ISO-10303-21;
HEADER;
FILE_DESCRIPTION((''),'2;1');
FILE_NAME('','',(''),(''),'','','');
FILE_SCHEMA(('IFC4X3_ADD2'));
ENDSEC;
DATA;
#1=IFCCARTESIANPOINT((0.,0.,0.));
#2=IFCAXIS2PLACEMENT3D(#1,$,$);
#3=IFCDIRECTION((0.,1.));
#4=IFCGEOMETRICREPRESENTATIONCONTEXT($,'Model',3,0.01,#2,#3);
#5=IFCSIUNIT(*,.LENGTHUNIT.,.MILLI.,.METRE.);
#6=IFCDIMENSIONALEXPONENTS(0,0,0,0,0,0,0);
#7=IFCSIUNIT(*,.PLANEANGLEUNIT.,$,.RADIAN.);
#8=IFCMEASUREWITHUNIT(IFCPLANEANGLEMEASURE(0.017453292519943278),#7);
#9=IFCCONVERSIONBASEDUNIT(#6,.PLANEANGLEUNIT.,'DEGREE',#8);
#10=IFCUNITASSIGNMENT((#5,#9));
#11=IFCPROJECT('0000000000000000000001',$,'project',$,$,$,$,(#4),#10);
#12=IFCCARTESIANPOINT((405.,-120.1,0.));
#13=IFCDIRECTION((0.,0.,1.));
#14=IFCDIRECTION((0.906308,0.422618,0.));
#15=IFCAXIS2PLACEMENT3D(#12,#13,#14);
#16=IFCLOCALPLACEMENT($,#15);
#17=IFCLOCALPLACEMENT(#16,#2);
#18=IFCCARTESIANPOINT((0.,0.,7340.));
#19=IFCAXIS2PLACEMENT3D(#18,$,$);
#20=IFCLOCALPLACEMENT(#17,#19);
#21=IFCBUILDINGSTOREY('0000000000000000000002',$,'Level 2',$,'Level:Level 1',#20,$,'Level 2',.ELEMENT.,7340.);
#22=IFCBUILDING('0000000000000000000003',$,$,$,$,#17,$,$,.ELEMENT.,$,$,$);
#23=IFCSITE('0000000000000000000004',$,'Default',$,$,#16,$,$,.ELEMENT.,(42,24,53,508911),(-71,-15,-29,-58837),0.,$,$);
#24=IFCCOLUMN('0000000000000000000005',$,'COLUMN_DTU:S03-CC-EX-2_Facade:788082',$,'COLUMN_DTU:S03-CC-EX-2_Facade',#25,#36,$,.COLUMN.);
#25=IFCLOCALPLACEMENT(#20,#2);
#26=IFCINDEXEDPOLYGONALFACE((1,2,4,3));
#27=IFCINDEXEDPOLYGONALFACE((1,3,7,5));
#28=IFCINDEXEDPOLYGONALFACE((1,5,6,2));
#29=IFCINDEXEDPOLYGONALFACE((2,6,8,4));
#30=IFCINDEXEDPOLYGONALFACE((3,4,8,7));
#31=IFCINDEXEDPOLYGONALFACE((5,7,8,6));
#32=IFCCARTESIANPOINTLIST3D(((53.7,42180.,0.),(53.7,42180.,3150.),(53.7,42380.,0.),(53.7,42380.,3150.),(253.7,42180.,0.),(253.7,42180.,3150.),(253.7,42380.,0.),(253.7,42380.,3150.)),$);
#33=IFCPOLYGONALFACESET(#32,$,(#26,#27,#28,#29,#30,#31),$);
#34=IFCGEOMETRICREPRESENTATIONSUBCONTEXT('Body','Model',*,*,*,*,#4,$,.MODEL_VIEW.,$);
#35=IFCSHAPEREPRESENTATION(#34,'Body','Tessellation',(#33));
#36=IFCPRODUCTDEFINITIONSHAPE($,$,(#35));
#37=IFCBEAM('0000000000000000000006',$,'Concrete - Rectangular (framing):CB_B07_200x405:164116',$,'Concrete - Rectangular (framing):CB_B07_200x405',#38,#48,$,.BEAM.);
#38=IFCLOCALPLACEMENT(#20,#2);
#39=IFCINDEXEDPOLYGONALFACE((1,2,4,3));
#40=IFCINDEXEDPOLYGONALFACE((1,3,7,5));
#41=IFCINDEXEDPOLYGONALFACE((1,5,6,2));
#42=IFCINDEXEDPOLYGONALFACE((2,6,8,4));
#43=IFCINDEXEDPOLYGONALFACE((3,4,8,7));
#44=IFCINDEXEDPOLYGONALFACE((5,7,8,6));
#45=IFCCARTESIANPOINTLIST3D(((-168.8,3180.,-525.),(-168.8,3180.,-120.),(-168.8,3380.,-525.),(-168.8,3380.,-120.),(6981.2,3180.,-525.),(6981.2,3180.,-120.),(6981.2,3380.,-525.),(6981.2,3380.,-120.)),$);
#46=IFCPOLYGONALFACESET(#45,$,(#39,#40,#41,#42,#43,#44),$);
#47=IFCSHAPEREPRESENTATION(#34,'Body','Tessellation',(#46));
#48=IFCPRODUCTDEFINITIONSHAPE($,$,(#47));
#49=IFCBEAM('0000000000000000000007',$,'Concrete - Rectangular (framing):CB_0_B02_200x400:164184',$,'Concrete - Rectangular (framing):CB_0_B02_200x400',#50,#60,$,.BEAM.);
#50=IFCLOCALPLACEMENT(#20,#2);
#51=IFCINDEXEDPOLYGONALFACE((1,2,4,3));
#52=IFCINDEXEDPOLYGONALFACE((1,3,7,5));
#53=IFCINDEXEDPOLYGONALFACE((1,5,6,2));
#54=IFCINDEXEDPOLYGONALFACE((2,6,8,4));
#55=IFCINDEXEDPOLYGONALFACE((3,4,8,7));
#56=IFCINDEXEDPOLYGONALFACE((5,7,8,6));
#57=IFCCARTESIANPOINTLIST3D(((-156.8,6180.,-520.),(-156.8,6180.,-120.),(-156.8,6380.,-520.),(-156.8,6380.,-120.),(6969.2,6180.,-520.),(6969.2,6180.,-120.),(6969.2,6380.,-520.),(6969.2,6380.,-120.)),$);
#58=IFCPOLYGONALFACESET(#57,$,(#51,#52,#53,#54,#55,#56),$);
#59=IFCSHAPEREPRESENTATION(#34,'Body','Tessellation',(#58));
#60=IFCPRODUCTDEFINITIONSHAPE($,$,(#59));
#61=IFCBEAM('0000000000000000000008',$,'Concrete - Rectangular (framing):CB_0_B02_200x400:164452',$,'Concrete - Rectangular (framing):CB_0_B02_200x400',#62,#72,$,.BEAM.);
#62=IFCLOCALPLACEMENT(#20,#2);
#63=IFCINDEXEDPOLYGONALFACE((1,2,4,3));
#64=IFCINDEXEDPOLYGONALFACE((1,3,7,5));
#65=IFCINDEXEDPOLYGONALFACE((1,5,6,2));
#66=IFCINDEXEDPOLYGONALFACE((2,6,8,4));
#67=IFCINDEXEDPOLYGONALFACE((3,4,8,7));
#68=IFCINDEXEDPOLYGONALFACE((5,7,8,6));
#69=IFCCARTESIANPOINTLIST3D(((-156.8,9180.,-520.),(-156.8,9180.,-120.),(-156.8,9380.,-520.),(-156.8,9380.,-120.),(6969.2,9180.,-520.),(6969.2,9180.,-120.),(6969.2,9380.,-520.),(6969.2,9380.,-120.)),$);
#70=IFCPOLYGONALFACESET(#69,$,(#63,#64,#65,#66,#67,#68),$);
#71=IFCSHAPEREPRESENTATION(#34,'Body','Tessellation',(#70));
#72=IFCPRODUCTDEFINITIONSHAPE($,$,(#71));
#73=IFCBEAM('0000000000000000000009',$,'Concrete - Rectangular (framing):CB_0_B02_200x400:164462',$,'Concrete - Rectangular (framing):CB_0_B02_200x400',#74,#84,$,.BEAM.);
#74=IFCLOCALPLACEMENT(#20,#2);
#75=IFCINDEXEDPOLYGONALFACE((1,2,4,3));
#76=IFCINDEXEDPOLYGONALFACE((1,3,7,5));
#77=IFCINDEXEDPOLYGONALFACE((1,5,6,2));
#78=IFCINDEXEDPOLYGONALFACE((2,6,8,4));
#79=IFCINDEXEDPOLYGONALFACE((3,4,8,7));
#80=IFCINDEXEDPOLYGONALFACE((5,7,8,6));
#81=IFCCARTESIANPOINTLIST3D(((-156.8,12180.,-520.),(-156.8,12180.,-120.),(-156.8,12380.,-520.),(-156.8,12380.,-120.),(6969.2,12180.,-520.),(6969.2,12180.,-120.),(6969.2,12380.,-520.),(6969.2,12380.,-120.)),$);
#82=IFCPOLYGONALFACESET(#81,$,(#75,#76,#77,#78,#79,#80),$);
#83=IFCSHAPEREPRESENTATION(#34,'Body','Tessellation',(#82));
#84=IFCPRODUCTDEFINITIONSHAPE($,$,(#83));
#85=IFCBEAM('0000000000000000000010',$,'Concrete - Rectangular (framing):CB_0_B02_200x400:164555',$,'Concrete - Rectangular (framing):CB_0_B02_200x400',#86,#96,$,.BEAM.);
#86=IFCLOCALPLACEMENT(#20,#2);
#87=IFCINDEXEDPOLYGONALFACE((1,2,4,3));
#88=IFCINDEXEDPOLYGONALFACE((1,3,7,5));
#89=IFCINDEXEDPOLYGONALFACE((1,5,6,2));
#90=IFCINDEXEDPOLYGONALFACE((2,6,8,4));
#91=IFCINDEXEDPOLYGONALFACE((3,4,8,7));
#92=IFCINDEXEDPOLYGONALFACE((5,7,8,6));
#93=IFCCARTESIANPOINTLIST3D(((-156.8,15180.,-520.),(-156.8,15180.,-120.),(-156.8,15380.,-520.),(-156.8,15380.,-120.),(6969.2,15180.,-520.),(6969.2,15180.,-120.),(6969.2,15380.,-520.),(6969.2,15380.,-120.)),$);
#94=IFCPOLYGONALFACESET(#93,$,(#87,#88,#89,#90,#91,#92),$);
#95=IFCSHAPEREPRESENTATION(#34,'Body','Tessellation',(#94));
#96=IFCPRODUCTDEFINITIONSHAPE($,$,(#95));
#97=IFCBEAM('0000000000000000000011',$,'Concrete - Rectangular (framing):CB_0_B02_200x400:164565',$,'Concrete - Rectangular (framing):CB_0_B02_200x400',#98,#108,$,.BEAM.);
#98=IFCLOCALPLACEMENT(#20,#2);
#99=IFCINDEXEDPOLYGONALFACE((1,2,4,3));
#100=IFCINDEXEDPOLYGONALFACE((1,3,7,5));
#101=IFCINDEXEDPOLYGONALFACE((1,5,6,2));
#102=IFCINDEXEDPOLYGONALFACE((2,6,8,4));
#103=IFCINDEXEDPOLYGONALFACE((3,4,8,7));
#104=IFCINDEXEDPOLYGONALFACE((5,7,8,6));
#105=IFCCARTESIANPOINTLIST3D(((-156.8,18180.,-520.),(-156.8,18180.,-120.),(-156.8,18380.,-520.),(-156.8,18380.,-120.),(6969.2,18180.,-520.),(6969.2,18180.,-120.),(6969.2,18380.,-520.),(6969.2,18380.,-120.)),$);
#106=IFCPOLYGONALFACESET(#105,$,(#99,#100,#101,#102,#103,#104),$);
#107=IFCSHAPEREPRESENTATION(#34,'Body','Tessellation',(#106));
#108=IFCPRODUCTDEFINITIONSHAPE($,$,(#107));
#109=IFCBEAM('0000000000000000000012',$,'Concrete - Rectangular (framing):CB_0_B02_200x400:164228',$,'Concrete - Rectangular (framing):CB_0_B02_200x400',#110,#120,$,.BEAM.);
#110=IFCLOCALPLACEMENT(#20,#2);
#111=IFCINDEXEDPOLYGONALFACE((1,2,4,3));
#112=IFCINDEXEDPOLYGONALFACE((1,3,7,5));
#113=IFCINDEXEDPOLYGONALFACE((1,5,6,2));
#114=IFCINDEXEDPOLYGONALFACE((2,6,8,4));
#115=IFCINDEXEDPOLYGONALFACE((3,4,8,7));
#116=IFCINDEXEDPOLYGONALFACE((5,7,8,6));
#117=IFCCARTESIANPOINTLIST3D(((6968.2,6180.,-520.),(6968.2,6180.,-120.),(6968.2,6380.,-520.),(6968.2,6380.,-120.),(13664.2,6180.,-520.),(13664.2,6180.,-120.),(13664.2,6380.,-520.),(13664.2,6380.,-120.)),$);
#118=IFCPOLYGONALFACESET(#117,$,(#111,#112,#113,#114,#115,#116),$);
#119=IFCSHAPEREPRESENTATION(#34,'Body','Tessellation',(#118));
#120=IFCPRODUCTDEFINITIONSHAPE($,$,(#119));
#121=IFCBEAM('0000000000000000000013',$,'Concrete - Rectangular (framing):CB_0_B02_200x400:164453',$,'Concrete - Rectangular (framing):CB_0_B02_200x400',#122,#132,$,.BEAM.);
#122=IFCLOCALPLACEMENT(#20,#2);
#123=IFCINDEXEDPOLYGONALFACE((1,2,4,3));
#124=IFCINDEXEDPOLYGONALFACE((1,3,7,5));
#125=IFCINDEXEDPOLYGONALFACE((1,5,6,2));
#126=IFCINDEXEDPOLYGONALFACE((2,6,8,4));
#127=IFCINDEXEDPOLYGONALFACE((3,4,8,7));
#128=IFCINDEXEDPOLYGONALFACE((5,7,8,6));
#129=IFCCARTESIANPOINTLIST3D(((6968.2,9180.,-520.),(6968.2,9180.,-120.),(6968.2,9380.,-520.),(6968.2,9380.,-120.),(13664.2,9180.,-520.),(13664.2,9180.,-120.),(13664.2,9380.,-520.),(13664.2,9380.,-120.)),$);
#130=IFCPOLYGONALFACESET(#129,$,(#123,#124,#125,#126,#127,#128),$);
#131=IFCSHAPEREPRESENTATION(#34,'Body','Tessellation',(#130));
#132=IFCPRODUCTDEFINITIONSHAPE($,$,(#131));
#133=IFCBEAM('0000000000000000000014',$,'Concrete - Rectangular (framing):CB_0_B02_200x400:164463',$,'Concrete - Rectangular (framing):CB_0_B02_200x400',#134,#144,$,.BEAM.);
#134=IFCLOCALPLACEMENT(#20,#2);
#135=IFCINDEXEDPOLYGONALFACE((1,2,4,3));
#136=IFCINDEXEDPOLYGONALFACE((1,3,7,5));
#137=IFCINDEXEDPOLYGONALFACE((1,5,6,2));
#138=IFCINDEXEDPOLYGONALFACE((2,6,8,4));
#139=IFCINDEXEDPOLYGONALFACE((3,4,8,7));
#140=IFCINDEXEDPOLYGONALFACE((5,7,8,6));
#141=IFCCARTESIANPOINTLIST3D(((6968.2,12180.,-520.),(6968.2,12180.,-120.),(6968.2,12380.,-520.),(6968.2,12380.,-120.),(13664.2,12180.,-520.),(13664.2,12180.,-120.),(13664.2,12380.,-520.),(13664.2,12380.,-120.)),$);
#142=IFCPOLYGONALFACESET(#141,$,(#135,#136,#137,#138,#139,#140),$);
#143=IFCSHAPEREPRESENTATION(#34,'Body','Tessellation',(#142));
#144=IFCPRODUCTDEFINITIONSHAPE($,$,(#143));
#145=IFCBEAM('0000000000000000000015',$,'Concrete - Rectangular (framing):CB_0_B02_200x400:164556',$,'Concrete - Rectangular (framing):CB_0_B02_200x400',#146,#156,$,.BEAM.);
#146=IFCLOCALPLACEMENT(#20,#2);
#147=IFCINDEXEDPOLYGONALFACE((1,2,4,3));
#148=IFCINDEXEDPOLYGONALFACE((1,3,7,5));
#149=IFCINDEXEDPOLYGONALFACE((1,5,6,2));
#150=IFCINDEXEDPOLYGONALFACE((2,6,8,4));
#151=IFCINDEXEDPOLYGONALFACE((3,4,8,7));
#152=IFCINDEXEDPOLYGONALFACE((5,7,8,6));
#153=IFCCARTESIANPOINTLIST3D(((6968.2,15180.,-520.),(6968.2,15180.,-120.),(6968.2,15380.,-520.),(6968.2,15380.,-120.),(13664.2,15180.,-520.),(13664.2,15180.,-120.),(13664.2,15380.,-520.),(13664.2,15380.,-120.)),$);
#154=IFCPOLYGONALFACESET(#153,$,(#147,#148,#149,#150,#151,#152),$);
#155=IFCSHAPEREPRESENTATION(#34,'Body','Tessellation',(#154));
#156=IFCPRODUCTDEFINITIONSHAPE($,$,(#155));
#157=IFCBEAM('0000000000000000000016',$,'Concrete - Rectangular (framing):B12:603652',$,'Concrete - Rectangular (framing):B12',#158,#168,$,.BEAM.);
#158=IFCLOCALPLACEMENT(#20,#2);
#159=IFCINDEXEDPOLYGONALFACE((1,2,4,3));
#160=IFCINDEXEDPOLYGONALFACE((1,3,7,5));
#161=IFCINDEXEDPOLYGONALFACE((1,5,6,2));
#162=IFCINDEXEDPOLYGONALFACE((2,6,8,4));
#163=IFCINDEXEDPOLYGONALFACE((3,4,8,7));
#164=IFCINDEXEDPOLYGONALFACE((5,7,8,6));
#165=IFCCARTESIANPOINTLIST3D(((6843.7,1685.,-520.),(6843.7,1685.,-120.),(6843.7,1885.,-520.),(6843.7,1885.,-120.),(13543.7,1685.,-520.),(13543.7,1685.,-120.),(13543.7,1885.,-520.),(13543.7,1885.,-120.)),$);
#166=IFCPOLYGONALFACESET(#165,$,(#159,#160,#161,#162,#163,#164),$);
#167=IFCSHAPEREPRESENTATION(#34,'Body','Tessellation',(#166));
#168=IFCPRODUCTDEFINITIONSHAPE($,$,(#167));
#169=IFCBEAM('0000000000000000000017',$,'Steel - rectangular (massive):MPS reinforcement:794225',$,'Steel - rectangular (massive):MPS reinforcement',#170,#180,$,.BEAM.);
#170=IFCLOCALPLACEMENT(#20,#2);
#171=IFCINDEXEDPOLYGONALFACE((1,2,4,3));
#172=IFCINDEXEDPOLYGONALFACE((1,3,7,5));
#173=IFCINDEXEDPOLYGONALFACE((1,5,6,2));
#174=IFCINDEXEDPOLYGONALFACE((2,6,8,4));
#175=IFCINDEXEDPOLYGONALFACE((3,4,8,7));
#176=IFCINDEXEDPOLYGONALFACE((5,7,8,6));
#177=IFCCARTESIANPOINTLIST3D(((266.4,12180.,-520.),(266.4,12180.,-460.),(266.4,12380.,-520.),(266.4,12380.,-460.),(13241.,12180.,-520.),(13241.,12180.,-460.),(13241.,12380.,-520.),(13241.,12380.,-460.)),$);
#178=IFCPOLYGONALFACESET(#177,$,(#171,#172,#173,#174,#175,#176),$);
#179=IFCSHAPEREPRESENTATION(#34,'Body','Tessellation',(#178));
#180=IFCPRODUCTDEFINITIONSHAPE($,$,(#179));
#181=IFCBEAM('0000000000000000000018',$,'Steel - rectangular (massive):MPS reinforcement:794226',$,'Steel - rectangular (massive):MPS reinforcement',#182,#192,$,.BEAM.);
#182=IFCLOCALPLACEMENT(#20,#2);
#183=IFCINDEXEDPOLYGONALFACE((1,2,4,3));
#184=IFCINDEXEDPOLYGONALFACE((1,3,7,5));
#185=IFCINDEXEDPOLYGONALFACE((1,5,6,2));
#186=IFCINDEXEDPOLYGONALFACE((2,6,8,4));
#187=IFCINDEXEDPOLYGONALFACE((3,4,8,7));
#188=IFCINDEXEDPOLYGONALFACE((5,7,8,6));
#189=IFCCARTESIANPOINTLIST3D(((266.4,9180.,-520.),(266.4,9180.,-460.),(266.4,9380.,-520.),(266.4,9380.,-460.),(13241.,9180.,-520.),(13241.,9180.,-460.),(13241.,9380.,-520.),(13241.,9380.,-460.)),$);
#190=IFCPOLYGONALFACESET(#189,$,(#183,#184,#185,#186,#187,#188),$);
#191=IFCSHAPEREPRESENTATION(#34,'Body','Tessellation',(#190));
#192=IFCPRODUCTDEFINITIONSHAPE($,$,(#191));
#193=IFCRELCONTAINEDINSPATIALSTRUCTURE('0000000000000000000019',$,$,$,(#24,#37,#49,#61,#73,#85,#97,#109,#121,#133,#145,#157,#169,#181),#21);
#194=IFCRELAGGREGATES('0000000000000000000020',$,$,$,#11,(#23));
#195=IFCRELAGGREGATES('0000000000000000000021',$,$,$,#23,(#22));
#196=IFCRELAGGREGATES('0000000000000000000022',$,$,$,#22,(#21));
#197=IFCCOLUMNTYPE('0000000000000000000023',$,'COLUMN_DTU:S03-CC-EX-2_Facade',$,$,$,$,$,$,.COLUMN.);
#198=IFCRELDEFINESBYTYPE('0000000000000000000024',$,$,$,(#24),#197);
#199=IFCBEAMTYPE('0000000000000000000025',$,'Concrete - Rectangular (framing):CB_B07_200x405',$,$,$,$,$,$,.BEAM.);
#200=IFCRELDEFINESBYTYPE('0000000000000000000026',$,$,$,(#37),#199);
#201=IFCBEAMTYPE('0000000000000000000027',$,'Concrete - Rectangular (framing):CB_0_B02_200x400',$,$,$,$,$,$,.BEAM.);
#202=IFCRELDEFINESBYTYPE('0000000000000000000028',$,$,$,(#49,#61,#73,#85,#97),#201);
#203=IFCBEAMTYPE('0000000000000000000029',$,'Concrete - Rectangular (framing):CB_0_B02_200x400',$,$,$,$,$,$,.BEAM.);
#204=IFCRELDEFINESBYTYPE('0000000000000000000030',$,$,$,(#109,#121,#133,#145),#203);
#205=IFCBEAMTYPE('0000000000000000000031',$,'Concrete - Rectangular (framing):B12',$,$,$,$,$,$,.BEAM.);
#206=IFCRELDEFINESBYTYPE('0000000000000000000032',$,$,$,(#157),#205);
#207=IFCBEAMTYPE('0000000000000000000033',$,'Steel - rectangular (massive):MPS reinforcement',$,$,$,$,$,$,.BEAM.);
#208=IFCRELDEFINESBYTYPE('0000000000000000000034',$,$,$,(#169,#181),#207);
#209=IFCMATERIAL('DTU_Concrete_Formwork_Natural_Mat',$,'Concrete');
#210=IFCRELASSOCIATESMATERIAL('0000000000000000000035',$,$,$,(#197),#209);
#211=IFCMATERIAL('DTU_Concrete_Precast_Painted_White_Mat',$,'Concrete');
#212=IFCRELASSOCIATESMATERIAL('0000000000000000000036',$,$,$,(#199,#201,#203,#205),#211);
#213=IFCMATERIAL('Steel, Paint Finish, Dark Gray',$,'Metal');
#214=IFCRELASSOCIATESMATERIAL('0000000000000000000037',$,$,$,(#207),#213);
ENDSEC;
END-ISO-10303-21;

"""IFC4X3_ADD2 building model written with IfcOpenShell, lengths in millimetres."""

from ifc_helpers import new_model, entity, si_unit, converted_unit, direction, frame, frame_2d, origin, origin_2d_with_axis, place, context, subcontext, project, spatial, rectangle, extrude, source, transform, mapped, material, material_profile, profile_set, type_object, type_shapes, element, save


model = new_model("IFC4X3_ADD2")

# Units and contexts
model_context = context("Model", 3, precision=0.01, world=origin(), true_north=direction((0.0, 1.0)))
body_context = subcontext(model_context, "Body", "Model", "MODEL_VIEW")
ifc_project = project(units=[si_unit("LENGTHUNIT", "METRE", prefix="MILLI"), converted_unit("PLANEANGLEUNIT", "DEGREE", entity("IfcPlaneAngleMeasure", 0.017453292519943278), si_unit("PLANEANGLEUNIT", "RADIAN"), dimensions=[0, 0, 0, 0, 0, 0, 0])], contexts=[model_context])

# Site, building, storey
site_placement = place(None, frame((405.0, -120.1, 0.0), z_axis=(0.0, 0.0, 1.0), x_axis=(0.906308, 0.422618, 0.0)))
site = spatial("IfcSite", under=ifc_project, at=site_placement, Name="Default", CompositionType="ELEMENT", RefLatitude=(42, 24, 53, 508911), RefLongitude=(-71, -15, -29, -58837), RefElevation=0.0)
building_placement = place(site_placement, origin())
building = spatial("IfcBuilding", under=site, at=building_placement, CompositionType="ELEMENT")
storey_placement = place(building_placement, frame((0.0, 0.0, 7340.0)))
storey = spatial("IfcBuildingStorey", under=building, at=storey_placement, Name="Level 2", ObjectType="Level:Level 1", LongName="Level 2", CompositionType="ELEMENT", Elevation=7340.0)

# Column
ifc_material_1 = material(Name="DTU_Concrete_Formwork_Natural_Mat", Category="Concrete")
ifc_material_profile_1 = material_profile(ifc_material_1, rectangle(XDim=200.0, YDim=200.0, at=frame_2d((0.0, 0.0), x_axis=(1.0, 0.0))), Name="S03-CC-EX-2_Facade")
ifc_profile_set_1 = profile_set([ifc_material_profile_1], Name="S03-CC-EX-2_Facade")
column_type = type_object("IfcColumnType", Name="COLUMN_DTU:S03-CC-EX-2_Facade", PredefinedType="COLUMN", material=ifc_profile_set_1)
shared_shape_1 = source(origin(), body_context, "Body", "SweptSolid", [
    extrude(rectangle(XDim=200.0, YDim=200.0, at=frame_2d((0.0, 0.0), x_axis=(1.0, 0.0))), frame((153.7, 42280.0, 7340.0), z_axis=(0.0, 0.0, 1.0), x_axis=(0.0, -1.0, 0.0)), (0.0, 0.0, 1.0), 3150.0),
])
type_shapes(column_type, [shared_shape_1])
column_placement = place(storey_placement, frame((0.0, 0.0, -7340.0)))
element("IfcColumn", 1, at=column_placement, inside=storey, type_object=column_type, Name="COLUMN_DTU:S03-CC-EX-2_Facade:788082", ObjectType="COLUMN_DTU:S03-CC-EX-2_Facade", PredefinedType="COLUMN", context=body_context, shape_type="MappedRepresentation", body=[
    mapped(shared_shape_1, transform((0.0, 0.0, 0.0), scale=1.0)),
])

# Beams
ifc_material_2 = material(Name="DTU_Concrete_Precast_Painted_White_Mat", Category="Concrete")
ifc_material_profile_2 = material_profile(ifc_material_2, rectangle(XDim=6850.0, YDim=200.0, at=origin_2d_with_axis()), Name="CB_B07_200x405")
ifc_profile_set_2 = profile_set([ifc_material_profile_2], Name="CB_B07_200x405")
beam_type_1 = type_object("IfcBeamType", Name="Concrete - Rectangular (framing):CB_B07_200x405", PredefinedType="BEAM", material=ifc_profile_set_2)
shared_shape_2 = source(origin(), body_context, "Body", "SweptSolid", [
    extrude(rectangle(XDim=7150.0, YDim=200.0, at=frame_2d((0.0, 0.0), x_axis=(1.0, 0.0))), frame((0.0, 0.0, -202.5), z_axis=(0.0, 0.0, 1.0), x_axis=(-1.0, 0.0, 0.0)), (0.0, 0.0, 1.0), 405.0),
])
type_shapes(beam_type_1, [shared_shape_2])
beam_1_placement = place(storey_placement, frame((3406.2, 3280.0, -322.5), z_axis=(0.0, 0.0, 1.0), x_axis=(-1.0, 0.0, 0.0)))
element("IfcBeam", 2, at=beam_1_placement, inside=storey, type_object=beam_type_1, Name="Concrete - Rectangular (framing):CB_B07_200x405:164116", ObjectType="Concrete - Rectangular (framing):CB_B07_200x405", PredefinedType="BEAM", context=body_context, shape_type="MappedRepresentation", body=[
    mapped(shared_shape_2, transform((0.0, 0.0, 0.0), scale=1.0)),
])
ifc_material_profile_3 = material_profile(ifc_material_2, rectangle(XDim=7035.5, YDim=200.0, at=frame_2d((0.0, 0.0), x_axis=(1.0, 0.0))), Name="CB_0_B02_200x400")
ifc_profile_set_3 = profile_set([ifc_material_profile_3], Name="CB_0_B02_200x400")
beam_type_2 = type_object("IfcBeamType", Name="Concrete - Rectangular (framing):CB_0_B02_200x400", PredefinedType="BEAM", material=ifc_profile_set_3)
shared_shape_3 = source(origin(), body_context, "Body", "SweptSolid", [
    extrude(rectangle(XDim=7126.0, YDim=200.0, at=origin_2d_with_axis()), frame((0.0, 0.0, -200.0), z_axis=(0.0, 0.0, 1.0), x_axis=(-1.0, 0.0, 0.0)), (0.0, 0.0, 1.0), 400.0),
])
type_shapes(beam_type_2, [shared_shape_3])
for number, where, z_axis, x_axis, name in (
    (3, (3406.2, 6280.0, -320.0), (0.0, 0.0, 1.0), (-1.0, 0.0, 0.0), "Concrete - Rectangular (framing):CB_0_B02_200x400:164184"),
    (4, (3406.2, 9280.0, -320.0), (0.0, 0.0, 1.0), (-1.0, 0.0, 0.0), "Concrete - Rectangular (framing):CB_0_B02_200x400:164452"),
    (5, (3406.2, 12280.0, -320.0), (0.0, 0.0, 1.0), (-1.0, 0.0, 0.0), "Concrete - Rectangular (framing):CB_0_B02_200x400:164462"),
    (6, (3406.2, 15280.0, -320.0), (0.0, 0.0, 1.0), (-1.0, 0.0, 0.0), "Concrete - Rectangular (framing):CB_0_B02_200x400:164555"),
    (7, (3406.2, 18280.0, -320.0), (0.0, 0.0, 1.0), (-1.0, 0.0, 0.0), "Concrete - Rectangular (framing):CB_0_B02_200x400:164565"),
):
    element("IfcBeam", number, at=place(storey_placement, frame(where, z_axis=z_axis, x_axis=x_axis)), inside=storey, type_object=beam_type_2, Name=name, ObjectType="Concrete - Rectangular (framing):CB_0_B02_200x400", PredefinedType="BEAM", context=body_context, shape_type="MappedRepresentation", body=[
        mapped(shared_shape_3, transform((0.0, 0.0, 0.0), scale=1.0)),
    ])
beam_type_3 = type_object("IfcBeamType", Name="Concrete - Rectangular (framing):CB_0_B02_200x400", PredefinedType="BEAM", material=ifc_profile_set_3)
shared_shape_4 = source(origin(), body_context, "Body", "SweptSolid", [
    extrude(rectangle(XDim=6696.0, YDim=200.0, at=frame_2d((0.0, 0.0), x_axis=(1.0, 0.0))), frame((0.0, 0.0, -200.0), z_axis=(0.0, 0.0, 1.0), x_axis=(-1.0, 0.0, 0.0)), (0.0, 0.0, 1.0), 400.0),
])
type_shapes(beam_type_3, [shared_shape_4])
for number, where, name in (
    (8, (10316.2, 6280.0, -320.0), "Concrete - Rectangular (framing):CB_0_B02_200x400:164228"),
    (9, (10316.2, 9280.0, -320.0), "Concrete - Rectangular (framing):CB_0_B02_200x400:164453"),
    (10, (10316.2, 12280.0, -320.0), "Concrete - Rectangular (framing):CB_0_B02_200x400:164463"),
    (11, (10316.2, 15280.0, -320.0), "Concrete - Rectangular (framing):CB_0_B02_200x400:164556"),
):
    element("IfcBeam", number, at=place(storey_placement, frame(where)), inside=storey, type_object=beam_type_3, Name=name, ObjectType="Concrete - Rectangular (framing):CB_0_B02_200x400", PredefinedType="BEAM", context=body_context, shape_type="MappedRepresentation", body=[
        mapped(shared_shape_4, transform((0.0, 0.0, 0.0), scale=1.0)),
    ])
ifc_material_profile_4 = material_profile(ifc_material_2, rectangle(XDim=6700.0, YDim=200.0, at=origin_2d_with_axis()), Name="B12")
ifc_profile_set_4 = profile_set([ifc_material_profile_4], Name="B12")
beam_type_4 = type_object("IfcBeamType", Name="Concrete - Rectangular (framing):B12", PredefinedType="BEAM", material=ifc_profile_set_4)
shared_shape_5 = source(origin(), body_context, "Body", "SweptSolid", [
    extrude(rectangle(XDim=6700.0, YDim=200.0, at=origin_2d_with_axis()), frame((32.5, 0.0, -200.0), z_axis=(0.0, 0.0, 1.0), x_axis=(-1.0, 0.0, 0.0)), (0.0, 0.0, 1.0), 400.0),
])
type_shapes(beam_type_4, [shared_shape_5])
beam_2_placement = place(storey_placement, frame((10161.2, 1785.0, -320.0)))
element("IfcBeam", 12, at=beam_2_placement, inside=storey, type_object=beam_type_4, Name="Concrete - Rectangular (framing):B12:603652", ObjectType="Concrete - Rectangular (framing):B12", PredefinedType="BEAM", context=body_context, shape_type="MappedRepresentation", body=[
    mapped(shared_shape_5, transform((0.0, 0.0, 0.0), scale=1.0)),
])
ifc_material_3 = material(Name="Steel, Paint Finish, Dark Gray", Category="Metal")
ifc_material_profile_5 = material_profile(ifc_material_3, rectangle(XDim=12974.6, YDim=200.0, at=origin_2d_with_axis()), Name="MPS reinforcement")
ifc_profile_set_5 = profile_set([ifc_material_profile_5], Name="MPS reinforcement")
beam_type_5 = type_object("IfcBeamType", Name="Steel - rectangular (massive):MPS reinforcement", PredefinedType="BEAM", material=ifc_profile_set_5)
shared_shape_6 = source(origin(), body_context, "Body", "SweptSolid", [
    extrude(rectangle(XDim=12974.6, YDim=200.0, at=origin_2d_with_axis()), frame((0.0, 0.0, -30.0), z_axis=(0.0, 0.0, 1.0), x_axis=(-1.0, 0.0, 0.0)), (0.0, 0.0, 1.0), 60.0),
])
type_shapes(beam_type_5, [shared_shape_6])
for number, where, name in (
    (13, (6753.7, 12280.0, -490.0), "Steel - rectangular (massive):MPS reinforcement:794225"),
    (14, (6753.7, 9280.0, -490.0), "Steel - rectangular (massive):MPS reinforcement:794226"),
):
    element("IfcBeam", number, at=place(storey_placement, frame(where)), inside=storey, type_object=beam_type_5, Name=name, ObjectType="Steel - rectangular (massive):MPS reinforcement", PredefinedType="BEAM", context=body_context, shape_type="MappedRepresentation", body=[
        mapped(shared_shape_6, transform((0.0, 0.0, 0.0), scale=1.0)),
    ])

save(model, "model.ifc")
